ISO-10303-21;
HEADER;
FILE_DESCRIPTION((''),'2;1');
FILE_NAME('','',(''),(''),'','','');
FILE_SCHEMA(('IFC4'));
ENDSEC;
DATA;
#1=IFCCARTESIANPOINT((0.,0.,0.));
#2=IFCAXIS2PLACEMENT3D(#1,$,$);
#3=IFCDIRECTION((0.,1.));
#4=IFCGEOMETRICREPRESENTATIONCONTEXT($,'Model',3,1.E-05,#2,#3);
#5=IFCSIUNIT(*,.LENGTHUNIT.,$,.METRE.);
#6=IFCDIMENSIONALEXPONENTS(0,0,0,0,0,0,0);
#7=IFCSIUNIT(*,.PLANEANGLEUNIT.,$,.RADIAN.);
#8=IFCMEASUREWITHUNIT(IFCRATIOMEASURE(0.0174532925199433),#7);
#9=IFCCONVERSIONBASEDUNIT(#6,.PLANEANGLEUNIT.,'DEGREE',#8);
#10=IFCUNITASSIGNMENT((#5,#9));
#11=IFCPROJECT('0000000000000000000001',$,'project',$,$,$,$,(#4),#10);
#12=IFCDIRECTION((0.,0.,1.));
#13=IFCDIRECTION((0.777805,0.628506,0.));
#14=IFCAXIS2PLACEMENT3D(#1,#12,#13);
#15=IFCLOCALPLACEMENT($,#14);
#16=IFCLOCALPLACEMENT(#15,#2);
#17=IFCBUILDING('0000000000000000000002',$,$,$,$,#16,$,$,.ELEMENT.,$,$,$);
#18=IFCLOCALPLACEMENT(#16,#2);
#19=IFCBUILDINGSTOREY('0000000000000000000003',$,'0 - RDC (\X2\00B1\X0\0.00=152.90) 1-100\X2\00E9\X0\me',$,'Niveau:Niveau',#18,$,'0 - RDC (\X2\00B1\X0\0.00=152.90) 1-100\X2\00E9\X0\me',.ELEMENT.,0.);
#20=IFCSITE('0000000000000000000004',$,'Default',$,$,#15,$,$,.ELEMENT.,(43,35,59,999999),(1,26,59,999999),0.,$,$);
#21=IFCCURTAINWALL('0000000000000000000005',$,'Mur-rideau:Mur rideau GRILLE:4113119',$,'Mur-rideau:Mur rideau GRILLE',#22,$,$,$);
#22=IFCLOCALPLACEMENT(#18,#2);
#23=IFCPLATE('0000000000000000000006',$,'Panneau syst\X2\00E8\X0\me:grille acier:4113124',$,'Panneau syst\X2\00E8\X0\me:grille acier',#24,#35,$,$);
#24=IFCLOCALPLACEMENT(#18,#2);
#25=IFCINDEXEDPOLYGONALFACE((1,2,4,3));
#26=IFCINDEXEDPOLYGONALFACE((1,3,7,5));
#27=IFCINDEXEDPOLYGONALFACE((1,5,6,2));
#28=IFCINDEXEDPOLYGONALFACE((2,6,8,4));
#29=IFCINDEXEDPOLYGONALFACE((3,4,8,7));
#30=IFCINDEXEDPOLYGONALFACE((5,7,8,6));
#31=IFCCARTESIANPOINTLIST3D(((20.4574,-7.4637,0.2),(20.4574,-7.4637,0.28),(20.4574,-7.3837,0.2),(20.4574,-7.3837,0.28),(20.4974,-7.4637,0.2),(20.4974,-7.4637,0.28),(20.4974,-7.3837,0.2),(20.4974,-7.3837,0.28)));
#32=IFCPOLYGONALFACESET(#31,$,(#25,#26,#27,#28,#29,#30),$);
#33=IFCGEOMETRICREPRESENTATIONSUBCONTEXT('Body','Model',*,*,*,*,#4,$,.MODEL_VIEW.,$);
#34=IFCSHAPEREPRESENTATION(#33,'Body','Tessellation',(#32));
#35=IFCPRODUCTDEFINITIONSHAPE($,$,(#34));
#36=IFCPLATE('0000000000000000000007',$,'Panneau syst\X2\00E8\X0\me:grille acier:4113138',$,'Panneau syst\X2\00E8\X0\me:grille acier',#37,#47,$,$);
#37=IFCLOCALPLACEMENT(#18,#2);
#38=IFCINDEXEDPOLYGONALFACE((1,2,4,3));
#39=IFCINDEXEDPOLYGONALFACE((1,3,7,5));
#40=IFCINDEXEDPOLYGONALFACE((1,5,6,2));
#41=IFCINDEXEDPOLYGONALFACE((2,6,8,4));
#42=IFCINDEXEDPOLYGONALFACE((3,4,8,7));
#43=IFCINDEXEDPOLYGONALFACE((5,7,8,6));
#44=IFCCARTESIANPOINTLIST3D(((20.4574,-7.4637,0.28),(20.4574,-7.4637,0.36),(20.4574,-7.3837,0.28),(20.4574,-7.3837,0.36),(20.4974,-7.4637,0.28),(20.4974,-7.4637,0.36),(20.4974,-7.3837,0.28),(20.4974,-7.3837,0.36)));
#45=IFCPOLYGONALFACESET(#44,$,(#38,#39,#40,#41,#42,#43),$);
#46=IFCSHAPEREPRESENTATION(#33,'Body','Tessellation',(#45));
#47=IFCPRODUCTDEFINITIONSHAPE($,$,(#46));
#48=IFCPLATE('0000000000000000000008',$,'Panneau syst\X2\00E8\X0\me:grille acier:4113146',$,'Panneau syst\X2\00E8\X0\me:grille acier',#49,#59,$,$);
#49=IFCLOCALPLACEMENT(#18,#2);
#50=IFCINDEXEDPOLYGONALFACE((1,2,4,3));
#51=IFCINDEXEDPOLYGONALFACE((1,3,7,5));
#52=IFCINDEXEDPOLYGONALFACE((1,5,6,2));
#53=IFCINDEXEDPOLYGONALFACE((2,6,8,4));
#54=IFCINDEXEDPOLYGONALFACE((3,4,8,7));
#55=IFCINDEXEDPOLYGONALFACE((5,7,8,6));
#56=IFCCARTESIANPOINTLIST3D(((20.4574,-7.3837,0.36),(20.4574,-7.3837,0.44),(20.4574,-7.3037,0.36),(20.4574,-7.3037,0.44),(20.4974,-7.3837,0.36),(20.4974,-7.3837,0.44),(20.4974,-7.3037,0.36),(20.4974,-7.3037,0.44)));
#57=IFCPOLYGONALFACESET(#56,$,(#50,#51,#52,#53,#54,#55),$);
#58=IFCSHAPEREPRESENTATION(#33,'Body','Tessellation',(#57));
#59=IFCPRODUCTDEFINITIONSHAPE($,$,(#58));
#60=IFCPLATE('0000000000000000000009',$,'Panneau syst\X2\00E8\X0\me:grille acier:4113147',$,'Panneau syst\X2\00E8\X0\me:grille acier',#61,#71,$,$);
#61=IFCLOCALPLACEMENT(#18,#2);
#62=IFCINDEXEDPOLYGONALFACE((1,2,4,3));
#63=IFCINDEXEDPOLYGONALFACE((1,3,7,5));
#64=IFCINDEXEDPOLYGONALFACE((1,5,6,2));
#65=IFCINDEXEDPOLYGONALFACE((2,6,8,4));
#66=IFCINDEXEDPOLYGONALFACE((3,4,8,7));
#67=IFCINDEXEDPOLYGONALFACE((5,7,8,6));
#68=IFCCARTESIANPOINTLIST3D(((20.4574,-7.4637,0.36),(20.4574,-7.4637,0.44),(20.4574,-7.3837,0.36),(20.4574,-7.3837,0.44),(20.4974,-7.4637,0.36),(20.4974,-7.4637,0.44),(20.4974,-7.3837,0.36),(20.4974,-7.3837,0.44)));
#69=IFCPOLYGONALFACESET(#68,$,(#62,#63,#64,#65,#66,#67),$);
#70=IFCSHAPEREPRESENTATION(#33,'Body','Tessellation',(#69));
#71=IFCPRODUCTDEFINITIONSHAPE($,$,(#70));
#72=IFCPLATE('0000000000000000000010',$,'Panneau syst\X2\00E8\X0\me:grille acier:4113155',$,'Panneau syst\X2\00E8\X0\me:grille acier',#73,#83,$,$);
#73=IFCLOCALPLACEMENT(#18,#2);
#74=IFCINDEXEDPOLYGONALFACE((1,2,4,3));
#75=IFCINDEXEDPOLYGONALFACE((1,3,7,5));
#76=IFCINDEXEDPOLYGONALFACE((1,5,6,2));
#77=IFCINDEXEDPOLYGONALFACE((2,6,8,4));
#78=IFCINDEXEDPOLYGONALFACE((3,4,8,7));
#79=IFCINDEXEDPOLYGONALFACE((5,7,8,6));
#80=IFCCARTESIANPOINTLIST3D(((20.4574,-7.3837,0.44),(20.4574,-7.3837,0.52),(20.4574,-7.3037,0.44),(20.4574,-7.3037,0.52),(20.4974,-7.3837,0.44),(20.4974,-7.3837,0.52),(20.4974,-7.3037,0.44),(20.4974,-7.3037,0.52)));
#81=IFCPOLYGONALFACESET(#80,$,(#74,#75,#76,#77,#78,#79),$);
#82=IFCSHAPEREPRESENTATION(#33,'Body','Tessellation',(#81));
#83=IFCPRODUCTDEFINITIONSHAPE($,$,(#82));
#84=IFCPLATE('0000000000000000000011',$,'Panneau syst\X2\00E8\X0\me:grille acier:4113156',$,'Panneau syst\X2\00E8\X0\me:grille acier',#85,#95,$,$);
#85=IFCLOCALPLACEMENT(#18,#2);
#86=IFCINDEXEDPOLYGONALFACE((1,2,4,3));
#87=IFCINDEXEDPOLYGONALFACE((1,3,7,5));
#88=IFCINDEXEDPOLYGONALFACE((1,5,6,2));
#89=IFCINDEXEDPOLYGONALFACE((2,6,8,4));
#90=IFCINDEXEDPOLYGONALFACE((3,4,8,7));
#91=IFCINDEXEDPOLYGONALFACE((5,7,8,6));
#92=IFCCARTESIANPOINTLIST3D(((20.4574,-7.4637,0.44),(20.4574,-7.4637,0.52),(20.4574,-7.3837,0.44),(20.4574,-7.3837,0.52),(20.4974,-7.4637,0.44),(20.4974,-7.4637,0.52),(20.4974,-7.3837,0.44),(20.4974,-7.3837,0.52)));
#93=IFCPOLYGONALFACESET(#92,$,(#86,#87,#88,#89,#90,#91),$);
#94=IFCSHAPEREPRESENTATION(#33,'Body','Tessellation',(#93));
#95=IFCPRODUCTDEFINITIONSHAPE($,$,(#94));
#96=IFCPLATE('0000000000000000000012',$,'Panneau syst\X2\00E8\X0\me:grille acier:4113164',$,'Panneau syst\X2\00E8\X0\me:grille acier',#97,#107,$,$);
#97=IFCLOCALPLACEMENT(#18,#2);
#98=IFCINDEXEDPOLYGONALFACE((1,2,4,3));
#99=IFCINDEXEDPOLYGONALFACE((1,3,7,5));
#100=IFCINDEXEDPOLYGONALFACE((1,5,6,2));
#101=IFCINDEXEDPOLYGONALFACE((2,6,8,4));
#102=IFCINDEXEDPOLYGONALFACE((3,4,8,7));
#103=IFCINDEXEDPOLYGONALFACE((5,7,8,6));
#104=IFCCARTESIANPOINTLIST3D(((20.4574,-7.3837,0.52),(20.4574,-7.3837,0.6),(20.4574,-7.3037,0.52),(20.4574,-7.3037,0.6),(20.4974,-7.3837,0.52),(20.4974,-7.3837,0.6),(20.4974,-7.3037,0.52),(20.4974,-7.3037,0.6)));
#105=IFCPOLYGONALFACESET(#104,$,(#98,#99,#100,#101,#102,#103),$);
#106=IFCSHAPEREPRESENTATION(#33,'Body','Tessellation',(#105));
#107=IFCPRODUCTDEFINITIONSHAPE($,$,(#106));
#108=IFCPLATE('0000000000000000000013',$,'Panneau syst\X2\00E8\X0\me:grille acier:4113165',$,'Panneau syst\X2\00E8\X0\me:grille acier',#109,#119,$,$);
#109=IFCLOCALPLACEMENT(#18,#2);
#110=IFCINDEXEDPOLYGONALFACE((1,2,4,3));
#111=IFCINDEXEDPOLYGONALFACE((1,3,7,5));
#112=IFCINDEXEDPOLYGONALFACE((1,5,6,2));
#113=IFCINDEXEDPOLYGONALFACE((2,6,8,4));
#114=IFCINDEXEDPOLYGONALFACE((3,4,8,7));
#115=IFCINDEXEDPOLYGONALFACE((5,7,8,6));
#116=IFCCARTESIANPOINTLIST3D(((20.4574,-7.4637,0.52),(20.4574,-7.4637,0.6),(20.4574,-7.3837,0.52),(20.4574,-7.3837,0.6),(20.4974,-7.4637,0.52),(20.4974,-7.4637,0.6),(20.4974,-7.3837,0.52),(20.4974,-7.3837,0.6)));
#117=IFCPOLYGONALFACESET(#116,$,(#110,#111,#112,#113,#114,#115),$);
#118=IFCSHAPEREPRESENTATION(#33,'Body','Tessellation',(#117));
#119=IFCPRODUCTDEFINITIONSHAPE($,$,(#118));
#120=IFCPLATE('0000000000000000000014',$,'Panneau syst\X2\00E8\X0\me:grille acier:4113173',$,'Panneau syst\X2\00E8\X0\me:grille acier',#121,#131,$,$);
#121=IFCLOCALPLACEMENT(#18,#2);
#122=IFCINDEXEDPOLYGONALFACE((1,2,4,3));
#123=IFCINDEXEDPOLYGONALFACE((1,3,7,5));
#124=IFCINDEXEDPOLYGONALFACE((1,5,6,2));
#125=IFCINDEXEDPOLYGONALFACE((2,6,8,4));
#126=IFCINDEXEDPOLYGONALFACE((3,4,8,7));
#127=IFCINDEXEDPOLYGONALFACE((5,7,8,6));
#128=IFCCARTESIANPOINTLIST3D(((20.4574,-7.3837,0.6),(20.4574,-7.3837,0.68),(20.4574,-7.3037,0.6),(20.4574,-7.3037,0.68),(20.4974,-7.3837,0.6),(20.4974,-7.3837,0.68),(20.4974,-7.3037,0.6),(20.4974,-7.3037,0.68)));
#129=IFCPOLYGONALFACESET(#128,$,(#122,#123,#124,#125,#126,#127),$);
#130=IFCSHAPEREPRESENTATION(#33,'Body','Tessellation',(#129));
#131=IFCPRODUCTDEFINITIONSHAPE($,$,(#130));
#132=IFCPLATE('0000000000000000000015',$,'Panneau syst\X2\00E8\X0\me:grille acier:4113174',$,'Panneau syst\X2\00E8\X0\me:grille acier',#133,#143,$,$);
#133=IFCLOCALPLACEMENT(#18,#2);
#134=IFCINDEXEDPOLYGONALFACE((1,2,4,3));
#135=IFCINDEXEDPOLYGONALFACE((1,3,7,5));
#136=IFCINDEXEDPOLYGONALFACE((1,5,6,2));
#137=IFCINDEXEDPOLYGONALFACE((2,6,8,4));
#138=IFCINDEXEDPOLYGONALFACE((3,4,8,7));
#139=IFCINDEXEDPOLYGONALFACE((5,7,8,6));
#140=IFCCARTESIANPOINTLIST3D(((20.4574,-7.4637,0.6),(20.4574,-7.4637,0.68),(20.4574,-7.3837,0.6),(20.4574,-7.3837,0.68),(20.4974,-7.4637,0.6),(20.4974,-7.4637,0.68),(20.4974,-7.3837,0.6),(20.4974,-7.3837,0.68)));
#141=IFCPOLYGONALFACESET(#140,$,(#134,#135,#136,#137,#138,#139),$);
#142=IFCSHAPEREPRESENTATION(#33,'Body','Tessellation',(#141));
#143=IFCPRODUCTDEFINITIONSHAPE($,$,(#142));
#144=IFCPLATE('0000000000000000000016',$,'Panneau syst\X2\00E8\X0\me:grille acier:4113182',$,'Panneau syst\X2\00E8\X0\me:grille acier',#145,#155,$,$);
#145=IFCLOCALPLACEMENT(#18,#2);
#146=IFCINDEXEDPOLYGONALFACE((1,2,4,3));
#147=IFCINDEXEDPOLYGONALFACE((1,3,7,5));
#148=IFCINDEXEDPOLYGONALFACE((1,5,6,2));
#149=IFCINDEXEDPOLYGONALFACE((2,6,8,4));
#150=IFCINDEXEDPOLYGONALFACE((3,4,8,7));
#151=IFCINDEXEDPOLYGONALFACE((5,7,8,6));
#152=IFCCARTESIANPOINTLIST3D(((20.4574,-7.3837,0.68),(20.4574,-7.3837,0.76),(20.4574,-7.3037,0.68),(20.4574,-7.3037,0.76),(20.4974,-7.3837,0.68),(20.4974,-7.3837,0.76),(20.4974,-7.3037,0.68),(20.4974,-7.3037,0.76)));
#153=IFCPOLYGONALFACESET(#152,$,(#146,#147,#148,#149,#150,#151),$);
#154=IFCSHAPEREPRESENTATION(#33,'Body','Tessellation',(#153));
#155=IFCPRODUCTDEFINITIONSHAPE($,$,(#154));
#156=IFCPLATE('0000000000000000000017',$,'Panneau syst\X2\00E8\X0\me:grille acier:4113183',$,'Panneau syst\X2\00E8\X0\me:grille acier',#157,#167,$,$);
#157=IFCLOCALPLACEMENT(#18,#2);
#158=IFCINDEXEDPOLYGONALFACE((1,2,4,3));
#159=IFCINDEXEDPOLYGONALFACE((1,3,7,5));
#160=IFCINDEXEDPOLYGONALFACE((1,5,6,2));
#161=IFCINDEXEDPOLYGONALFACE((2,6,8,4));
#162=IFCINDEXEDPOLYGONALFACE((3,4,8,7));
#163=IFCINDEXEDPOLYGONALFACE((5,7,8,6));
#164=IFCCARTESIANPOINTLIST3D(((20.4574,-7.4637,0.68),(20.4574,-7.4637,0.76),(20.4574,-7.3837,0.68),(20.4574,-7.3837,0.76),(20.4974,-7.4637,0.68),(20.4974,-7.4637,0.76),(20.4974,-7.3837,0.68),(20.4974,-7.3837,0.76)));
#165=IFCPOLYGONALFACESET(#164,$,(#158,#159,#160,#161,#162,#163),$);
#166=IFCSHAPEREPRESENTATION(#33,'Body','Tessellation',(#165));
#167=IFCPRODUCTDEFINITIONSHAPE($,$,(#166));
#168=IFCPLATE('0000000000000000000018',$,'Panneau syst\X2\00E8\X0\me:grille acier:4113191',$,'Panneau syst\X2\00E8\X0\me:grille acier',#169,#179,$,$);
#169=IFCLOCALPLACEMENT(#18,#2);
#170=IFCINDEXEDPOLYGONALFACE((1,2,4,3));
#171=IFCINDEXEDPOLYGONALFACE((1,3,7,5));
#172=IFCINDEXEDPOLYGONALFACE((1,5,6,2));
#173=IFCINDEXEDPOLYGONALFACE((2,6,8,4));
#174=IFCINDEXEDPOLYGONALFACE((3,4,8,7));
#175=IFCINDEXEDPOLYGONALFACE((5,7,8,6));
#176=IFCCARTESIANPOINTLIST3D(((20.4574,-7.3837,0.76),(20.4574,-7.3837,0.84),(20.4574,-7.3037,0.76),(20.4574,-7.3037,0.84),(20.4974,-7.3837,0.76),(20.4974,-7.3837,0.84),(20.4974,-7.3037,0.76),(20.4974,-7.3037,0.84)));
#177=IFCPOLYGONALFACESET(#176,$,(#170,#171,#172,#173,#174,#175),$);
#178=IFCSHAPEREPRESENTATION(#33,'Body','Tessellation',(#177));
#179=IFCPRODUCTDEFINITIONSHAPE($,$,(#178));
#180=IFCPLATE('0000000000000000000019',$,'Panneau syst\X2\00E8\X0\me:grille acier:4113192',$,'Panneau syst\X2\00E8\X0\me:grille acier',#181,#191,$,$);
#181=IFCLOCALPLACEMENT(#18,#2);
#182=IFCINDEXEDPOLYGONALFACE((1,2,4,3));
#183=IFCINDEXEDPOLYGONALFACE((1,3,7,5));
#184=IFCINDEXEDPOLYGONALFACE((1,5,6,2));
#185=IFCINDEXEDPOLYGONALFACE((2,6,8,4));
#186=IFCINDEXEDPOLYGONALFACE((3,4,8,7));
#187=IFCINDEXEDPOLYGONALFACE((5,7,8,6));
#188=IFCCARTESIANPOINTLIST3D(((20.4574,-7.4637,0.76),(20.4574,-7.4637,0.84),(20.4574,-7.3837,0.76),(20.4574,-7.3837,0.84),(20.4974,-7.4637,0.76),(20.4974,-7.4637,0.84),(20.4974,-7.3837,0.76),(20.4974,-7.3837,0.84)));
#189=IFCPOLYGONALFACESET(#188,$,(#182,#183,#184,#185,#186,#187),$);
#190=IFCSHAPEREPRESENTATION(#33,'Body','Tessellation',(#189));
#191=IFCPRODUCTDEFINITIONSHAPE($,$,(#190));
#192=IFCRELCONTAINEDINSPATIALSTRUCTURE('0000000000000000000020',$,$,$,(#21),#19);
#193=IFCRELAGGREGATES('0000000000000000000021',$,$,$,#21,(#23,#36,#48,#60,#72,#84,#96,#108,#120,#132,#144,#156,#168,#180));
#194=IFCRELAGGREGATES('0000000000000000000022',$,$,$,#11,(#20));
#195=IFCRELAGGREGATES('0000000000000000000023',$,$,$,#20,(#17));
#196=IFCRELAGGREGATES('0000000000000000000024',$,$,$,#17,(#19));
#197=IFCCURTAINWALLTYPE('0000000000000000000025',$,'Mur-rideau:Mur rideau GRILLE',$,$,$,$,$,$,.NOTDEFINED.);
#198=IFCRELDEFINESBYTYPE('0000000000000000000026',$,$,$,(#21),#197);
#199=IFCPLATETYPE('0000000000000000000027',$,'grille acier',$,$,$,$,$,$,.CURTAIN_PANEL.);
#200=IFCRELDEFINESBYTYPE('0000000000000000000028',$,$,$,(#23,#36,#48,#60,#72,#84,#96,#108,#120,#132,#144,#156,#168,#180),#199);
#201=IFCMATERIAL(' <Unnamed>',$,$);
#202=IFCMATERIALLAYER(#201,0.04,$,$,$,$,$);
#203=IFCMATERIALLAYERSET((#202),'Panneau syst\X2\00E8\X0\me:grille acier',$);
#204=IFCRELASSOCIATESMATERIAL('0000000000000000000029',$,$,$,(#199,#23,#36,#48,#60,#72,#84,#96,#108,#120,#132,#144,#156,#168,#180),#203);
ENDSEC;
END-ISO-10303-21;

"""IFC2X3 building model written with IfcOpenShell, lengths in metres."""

from ifc_helpers import new_model, entity, si_unit, converted_unit, direction, frame, origin, origin_2d_with_axis, place, context, subcontext, project, spatial, rectangle, extrude, source, transform, mapped, material, layer, layer_set, layer_usage, type_object, type_shapes, element, aggregate, save


model = new_model("IFC2X3")

# Units and contexts
model_context = context("Model", 3, precision=1e-05, world=origin(), true_north=direction((0.0, 1.0)))
body_context = subcontext(model_context, "Body", "Model", "MODEL_VIEW")
ifc_project = project(units=[si_unit("LENGTHUNIT", "METRE"), converted_unit("PLANEANGLEUNIT", "DEGREE", entity("IfcRatioMeasure", 0.0174532925199433), si_unit("PLANEANGLEUNIT", "RADIAN"), dimensions=[0, 0, 0, 0, 0, 0, 0])], contexts=[model_context])

# Site, building, storey
site_placement = place(None, frame((0.0, 0.0, 0.0), z_axis=(0.0, 0.0, 1.0), x_axis=(0.777805, 0.628506, 0.0)))
site = spatial("IfcSite", under=ifc_project, at=site_placement, Name="Default", CompositionType="ELEMENT", RefLatitude=(43, 35, 59, 999999), RefLongitude=(1, 26, 59, 999999), RefElevation=0.0)
building_placement = place(site_placement, origin())
building = spatial("IfcBuilding", under=site, at=building_placement, CompositionType="ELEMENT")
storey_placement = place(building_placement, origin())
storey = spatial("IfcBuildingStorey", under=building, at=storey_placement, Name="0 - RDC (±0.00=152.90) 1-100éme", ObjectType="Niveau:Niveau", LongName="0 - RDC (±0.00=152.90) 1-100éme", CompositionType="ELEMENT", Elevation=0.0)

# Curtain wall, plates
curtain_wall_type = type_object("IfcCurtainWallType", Name="Mur-rideau:Mur rideau GRILLE", PredefinedType="NOTDEFINED")
curtain_wall_placement = place(storey_placement, origin())
curtain_wall = element("IfcCurtainWall", 1, at=curtain_wall_placement, inside=storey, type_object=curtain_wall_type, Name="Mur-rideau:Mur rideau GRILLE:4113119", ObjectType="Mur-rideau:Mur rideau GRILLE")
ifc_material = material(Name=" <Unnamed>")
ifc_layer = layer(ifc_material, 0.04)
ifc_layer_set = layer_set([ifc_layer], Name="Panneau système:grille acier")
ifc_layer_usage_1 = layer_usage(ifc_layer_set, "AXIS3", "POSITIVE", 0.0)
plate_type_1 = type_object("IfcPlateType", Name="grille acier", PredefinedType="CURTAIN_PANEL", material=ifc_layer_set)
shared_shape_1 = source(origin(), body_context, "Body", "SweptSolid", [
    extrude(rectangle(XDim=0.04, YDim=0.08, at=origin_2d_with_axis()), frame((0.0, 0.0, 0.0), z_axis=(0.0, 0.0, 1.0), x_axis=(0.0, 1.0, 0.0)), (0.0, 0.0, 1.0), 0.08),
])
type_shapes(plate_type_1, [shared_shape_1])
plate_1_placement = place(curtain_wall_placement, frame((20.4774, -7.4237, 0.2), z_axis=(0.0, 0.0, 1.0), x_axis=(0.0, -1.0, 0.0)))
plate_1 = element("IfcPlate", 2, at=plate_1_placement, type_object=plate_type_1, material=ifc_layer_usage_1, Name="Panneau système:grille acier:4113124", ObjectType="Panneau système:grille acier", context=body_context, shape_type="MappedRepresentation", body=[
    mapped(shared_shape_1, transform((0.0, 0.0, 0.0), scale=1.0)),
])
ifc_layer_usage_2 = layer_usage(ifc_layer_set, "AXIS3", "POSITIVE", 0.0)
plate_2_placement = place(curtain_wall_placement, frame((20.4774, -7.4237, 0.28), z_axis=(0.0, 0.0, 1.0), x_axis=(0.0, -1.0, 0.0)))
plate_2 = element("IfcPlate", 3, at=plate_2_placement, type_object=plate_type_1, material=ifc_layer_usage_2, Name="Panneau système:grille acier:4113138", ObjectType="Panneau système:grille acier", context=body_context, shape_type="MappedRepresentation", body=[
    mapped(shared_shape_1, transform((0.0, 0.0, 0.0), scale=1.0)),
])
ifc_layer_usage_3 = layer_usage(ifc_layer_set, "AXIS3", "POSITIVE", 0.0)
plate_3_placement = place(curtain_wall_placement, frame((20.4774, -7.3437, 0.36), z_axis=(0.0, 0.0, 1.0), x_axis=(0.0, -1.0, 0.0)))
plate_3 = element("IfcPlate", 4, at=plate_3_placement, type_object=plate_type_1, material=ifc_layer_usage_3, Name="Panneau système:grille acier:4113146", ObjectType="Panneau système:grille acier", context=body_context, shape_type="MappedRepresentation", body=[
    mapped(shared_shape_1, transform((0.0, 0.0, 0.0), scale=1.0)),
])
ifc_layer_usage_4 = layer_usage(ifc_layer_set, "AXIS3", "POSITIVE", 0.0)
plate_4_placement = place(curtain_wall_placement, frame((20.4774, -7.4237, 0.36), z_axis=(0.0, 0.0, 1.0), x_axis=(0.0, -1.0, 0.0)))
plate_4 = element("IfcPlate", 5, at=plate_4_placement, type_object=plate_type_1, material=ifc_layer_usage_4, Name="Panneau système:grille acier:4113147", ObjectType="Panneau système:grille acier", context=body_context, shape_type="MappedRepresentation", body=[
    mapped(shared_shape_1, transform((0.0, 0.0, 0.0), scale=1.0)),
])
ifc_layer_usage_5 = layer_usage(ifc_layer_set, "AXIS3", "POSITIVE", 0.0)
plate_5_placement = place(curtain_wall_placement, frame((20.4774, -7.3437, 0.44), z_axis=(0.0, 0.0, 1.0), x_axis=(0.0, -1.0, 0.0)))
plate_5 = element("IfcPlate", 6, at=plate_5_placement, type_object=plate_type_1, material=ifc_layer_usage_5, Name="Panneau système:grille acier:4113155", ObjectType="Panneau système:grille acier", context=body_context, shape_type="MappedRepresentation", body=[
    mapped(shared_shape_1, transform((0.0, 0.0, 0.0), scale=1.0)),
])
ifc_layer_usage_6 = layer_usage(ifc_layer_set, "AXIS3", "POSITIVE", 0.0)
plate_6_placement = place(curtain_wall_placement, frame((20.4774, -7.4237, 0.44), z_axis=(0.0, 0.0, 1.0), x_axis=(0.0, -1.0, 0.0)))
plate_6 = element("IfcPlate", 7, at=plate_6_placement, type_object=plate_type_1, material=ifc_layer_usage_6, Name="Panneau système:grille acier:4113156", ObjectType="Panneau système:grille acier", context=body_context, shape_type="MappedRepresentation", body=[
    mapped(shared_shape_1, transform((0.0, 0.0, 0.0), scale=1.0)),
])
ifc_layer_usage_7 = layer_usage(ifc_layer_set, "AXIS3", "POSITIVE", 0.0)
plate_7_placement = place(curtain_wall_placement, frame((20.4774, -7.3437, 0.52), z_axis=(0.0, 0.0, 1.0), x_axis=(0.0, -1.0, 0.0)))
plate_7 = element("IfcPlate", 8, at=plate_7_placement, type_object=plate_type_1, material=ifc_layer_usage_7, Name="Panneau système:grille acier:4113164", ObjectType="Panneau système:grille acier", context=body_context, shape_type="MappedRepresentation", body=[
    mapped(shared_shape_1, transform((0.0, 0.0, 0.0), scale=1.0)),
])
ifc_layer_usage_8 = layer_usage(ifc_layer_set, "AXIS3", "POSITIVE", 0.0)
plate_8_placement = place(curtain_wall_placement, frame((20.4774, -7.4237, 0.52), z_axis=(0.0, 0.0, 1.0), x_axis=(0.0, -1.0, 0.0)))
plate_8 = element("IfcPlate", 9, at=plate_8_placement, type_object=plate_type_1, material=ifc_layer_usage_8, Name="Panneau système:grille acier:4113165", ObjectType="Panneau système:grille acier", context=body_context, shape_type="MappedRepresentation", body=[
    mapped(shared_shape_1, transform((0.0, 0.0, 0.0), scale=1.0)),
])
ifc_layer_usage_9 = layer_usage(ifc_layer_set, "AXIS3", "POSITIVE", 0.0)
plate_9_placement = place(curtain_wall_placement, frame((20.4774, -7.3437, 0.6), z_axis=(0.0, 0.0, 1.0), x_axis=(0.0, -1.0, 0.0)))
plate_9 = element("IfcPlate", 10, at=plate_9_placement, type_object=plate_type_1, material=ifc_layer_usage_9, Name="Panneau système:grille acier:4113173", ObjectType="Panneau système:grille acier", context=body_context, shape_type="MappedRepresentation", body=[
    mapped(shared_shape_1, transform((0.0, 0.0, 0.0), scale=1.0)),
])
ifc_layer_usage_10 = layer_usage(ifc_layer_set, "AXIS3", "POSITIVE", 0.0)
plate_10_placement = place(curtain_wall_placement, frame((20.4774, -7.4237, 0.6), z_axis=(0.0, 0.0, 1.0), x_axis=(0.0, -1.0, 0.0)))
plate_10 = element("IfcPlate", 11, at=plate_10_placement, type_object=plate_type_1, material=ifc_layer_usage_10, Name="Panneau système:grille acier:4113174", ObjectType="Panneau système:grille acier", context=body_context, shape_type="MappedRepresentation", body=[
    mapped(shared_shape_1, transform((0.0, 0.0, 0.0), scale=1.0)),
])
ifc_layer_usage_11 = layer_usage(ifc_layer_set, "AXIS3", "POSITIVE", 0.0)
plate_11_placement = place(curtain_wall_placement, frame((20.4774, -7.3437, 0.68), z_axis=(0.0, 0.0, 1.0), x_axis=(0.0, -1.0, 0.0)))
plate_11 = element("IfcPlate", 12, at=plate_11_placement, type_object=plate_type_1, material=ifc_layer_usage_11, Name="Panneau système:grille acier:4113182", ObjectType="Panneau système:grille acier", context=body_context, shape_type="MappedRepresentation", body=[
    mapped(shared_shape_1, transform((0.0, 0.0, 0.0), scale=1.0)),
])
ifc_layer_usage_12 = layer_usage(ifc_layer_set, "AXIS3", "POSITIVE", 0.0)
plate_12_placement = place(curtain_wall_placement, frame((20.4774, -7.4237, 0.68), z_axis=(0.0, 0.0, 1.0), x_axis=(0.0, -1.0, 0.0)))
plate_12 = element("IfcPlate", 13, at=plate_12_placement, type_object=plate_type_1, material=ifc_layer_usage_12, Name="Panneau système:grille acier:4113183", ObjectType="Panneau système:grille acier", context=body_context, shape_type="MappedRepresentation", body=[
    mapped(shared_shape_1, transform((0.0, 0.0, 0.0), scale=1.0)),
])
ifc_layer_usage_13 = layer_usage(ifc_layer_set, "AXIS3", "POSITIVE", 0.0)
plate_13_placement = place(curtain_wall_placement, frame((20.4774, -7.3437, 0.76), z_axis=(0.0, 0.0, 1.0), x_axis=(0.0, -1.0, 0.0)))
plate_13 = element("IfcPlate", 14, at=plate_13_placement, type_object=plate_type_1, material=ifc_layer_usage_13, Name="Panneau système:grille acier:4113191", ObjectType="Panneau système:grille acier", context=body_context, shape_type="MappedRepresentation", body=[
    mapped(shared_shape_1, transform((0.0, 0.0, 0.0), scale=1.0)),
])
ifc_layer_usage_14 = layer_usage(ifc_layer_set, "AXIS3", "POSITIVE", 0.0)
plate_14_placement = place(curtain_wall_placement, frame((20.4774, -7.4237, 0.76), z_axis=(0.0, 0.0, 1.0), x_axis=(0.0, -1.0, 0.0)))
plate_14 = element("IfcPlate", 15, at=plate_14_placement, type_object=plate_type_1, material=ifc_layer_usage_14, Name="Panneau système:grille acier:4113192", ObjectType="Panneau système:grille acier", context=body_context, shape_type="MappedRepresentation", body=[
    mapped(shared_shape_1, transform((0.0, 0.0, 0.0), scale=1.0)),
])
aggregate(curtain_wall, [plate_1, plate_2, plate_3, plate_4, plate_5, plate_6, plate_7, plate_8, plate_9, plate_10, plate_11, plate_12, plate_13, plate_14])

save(model, "model.ifc")
